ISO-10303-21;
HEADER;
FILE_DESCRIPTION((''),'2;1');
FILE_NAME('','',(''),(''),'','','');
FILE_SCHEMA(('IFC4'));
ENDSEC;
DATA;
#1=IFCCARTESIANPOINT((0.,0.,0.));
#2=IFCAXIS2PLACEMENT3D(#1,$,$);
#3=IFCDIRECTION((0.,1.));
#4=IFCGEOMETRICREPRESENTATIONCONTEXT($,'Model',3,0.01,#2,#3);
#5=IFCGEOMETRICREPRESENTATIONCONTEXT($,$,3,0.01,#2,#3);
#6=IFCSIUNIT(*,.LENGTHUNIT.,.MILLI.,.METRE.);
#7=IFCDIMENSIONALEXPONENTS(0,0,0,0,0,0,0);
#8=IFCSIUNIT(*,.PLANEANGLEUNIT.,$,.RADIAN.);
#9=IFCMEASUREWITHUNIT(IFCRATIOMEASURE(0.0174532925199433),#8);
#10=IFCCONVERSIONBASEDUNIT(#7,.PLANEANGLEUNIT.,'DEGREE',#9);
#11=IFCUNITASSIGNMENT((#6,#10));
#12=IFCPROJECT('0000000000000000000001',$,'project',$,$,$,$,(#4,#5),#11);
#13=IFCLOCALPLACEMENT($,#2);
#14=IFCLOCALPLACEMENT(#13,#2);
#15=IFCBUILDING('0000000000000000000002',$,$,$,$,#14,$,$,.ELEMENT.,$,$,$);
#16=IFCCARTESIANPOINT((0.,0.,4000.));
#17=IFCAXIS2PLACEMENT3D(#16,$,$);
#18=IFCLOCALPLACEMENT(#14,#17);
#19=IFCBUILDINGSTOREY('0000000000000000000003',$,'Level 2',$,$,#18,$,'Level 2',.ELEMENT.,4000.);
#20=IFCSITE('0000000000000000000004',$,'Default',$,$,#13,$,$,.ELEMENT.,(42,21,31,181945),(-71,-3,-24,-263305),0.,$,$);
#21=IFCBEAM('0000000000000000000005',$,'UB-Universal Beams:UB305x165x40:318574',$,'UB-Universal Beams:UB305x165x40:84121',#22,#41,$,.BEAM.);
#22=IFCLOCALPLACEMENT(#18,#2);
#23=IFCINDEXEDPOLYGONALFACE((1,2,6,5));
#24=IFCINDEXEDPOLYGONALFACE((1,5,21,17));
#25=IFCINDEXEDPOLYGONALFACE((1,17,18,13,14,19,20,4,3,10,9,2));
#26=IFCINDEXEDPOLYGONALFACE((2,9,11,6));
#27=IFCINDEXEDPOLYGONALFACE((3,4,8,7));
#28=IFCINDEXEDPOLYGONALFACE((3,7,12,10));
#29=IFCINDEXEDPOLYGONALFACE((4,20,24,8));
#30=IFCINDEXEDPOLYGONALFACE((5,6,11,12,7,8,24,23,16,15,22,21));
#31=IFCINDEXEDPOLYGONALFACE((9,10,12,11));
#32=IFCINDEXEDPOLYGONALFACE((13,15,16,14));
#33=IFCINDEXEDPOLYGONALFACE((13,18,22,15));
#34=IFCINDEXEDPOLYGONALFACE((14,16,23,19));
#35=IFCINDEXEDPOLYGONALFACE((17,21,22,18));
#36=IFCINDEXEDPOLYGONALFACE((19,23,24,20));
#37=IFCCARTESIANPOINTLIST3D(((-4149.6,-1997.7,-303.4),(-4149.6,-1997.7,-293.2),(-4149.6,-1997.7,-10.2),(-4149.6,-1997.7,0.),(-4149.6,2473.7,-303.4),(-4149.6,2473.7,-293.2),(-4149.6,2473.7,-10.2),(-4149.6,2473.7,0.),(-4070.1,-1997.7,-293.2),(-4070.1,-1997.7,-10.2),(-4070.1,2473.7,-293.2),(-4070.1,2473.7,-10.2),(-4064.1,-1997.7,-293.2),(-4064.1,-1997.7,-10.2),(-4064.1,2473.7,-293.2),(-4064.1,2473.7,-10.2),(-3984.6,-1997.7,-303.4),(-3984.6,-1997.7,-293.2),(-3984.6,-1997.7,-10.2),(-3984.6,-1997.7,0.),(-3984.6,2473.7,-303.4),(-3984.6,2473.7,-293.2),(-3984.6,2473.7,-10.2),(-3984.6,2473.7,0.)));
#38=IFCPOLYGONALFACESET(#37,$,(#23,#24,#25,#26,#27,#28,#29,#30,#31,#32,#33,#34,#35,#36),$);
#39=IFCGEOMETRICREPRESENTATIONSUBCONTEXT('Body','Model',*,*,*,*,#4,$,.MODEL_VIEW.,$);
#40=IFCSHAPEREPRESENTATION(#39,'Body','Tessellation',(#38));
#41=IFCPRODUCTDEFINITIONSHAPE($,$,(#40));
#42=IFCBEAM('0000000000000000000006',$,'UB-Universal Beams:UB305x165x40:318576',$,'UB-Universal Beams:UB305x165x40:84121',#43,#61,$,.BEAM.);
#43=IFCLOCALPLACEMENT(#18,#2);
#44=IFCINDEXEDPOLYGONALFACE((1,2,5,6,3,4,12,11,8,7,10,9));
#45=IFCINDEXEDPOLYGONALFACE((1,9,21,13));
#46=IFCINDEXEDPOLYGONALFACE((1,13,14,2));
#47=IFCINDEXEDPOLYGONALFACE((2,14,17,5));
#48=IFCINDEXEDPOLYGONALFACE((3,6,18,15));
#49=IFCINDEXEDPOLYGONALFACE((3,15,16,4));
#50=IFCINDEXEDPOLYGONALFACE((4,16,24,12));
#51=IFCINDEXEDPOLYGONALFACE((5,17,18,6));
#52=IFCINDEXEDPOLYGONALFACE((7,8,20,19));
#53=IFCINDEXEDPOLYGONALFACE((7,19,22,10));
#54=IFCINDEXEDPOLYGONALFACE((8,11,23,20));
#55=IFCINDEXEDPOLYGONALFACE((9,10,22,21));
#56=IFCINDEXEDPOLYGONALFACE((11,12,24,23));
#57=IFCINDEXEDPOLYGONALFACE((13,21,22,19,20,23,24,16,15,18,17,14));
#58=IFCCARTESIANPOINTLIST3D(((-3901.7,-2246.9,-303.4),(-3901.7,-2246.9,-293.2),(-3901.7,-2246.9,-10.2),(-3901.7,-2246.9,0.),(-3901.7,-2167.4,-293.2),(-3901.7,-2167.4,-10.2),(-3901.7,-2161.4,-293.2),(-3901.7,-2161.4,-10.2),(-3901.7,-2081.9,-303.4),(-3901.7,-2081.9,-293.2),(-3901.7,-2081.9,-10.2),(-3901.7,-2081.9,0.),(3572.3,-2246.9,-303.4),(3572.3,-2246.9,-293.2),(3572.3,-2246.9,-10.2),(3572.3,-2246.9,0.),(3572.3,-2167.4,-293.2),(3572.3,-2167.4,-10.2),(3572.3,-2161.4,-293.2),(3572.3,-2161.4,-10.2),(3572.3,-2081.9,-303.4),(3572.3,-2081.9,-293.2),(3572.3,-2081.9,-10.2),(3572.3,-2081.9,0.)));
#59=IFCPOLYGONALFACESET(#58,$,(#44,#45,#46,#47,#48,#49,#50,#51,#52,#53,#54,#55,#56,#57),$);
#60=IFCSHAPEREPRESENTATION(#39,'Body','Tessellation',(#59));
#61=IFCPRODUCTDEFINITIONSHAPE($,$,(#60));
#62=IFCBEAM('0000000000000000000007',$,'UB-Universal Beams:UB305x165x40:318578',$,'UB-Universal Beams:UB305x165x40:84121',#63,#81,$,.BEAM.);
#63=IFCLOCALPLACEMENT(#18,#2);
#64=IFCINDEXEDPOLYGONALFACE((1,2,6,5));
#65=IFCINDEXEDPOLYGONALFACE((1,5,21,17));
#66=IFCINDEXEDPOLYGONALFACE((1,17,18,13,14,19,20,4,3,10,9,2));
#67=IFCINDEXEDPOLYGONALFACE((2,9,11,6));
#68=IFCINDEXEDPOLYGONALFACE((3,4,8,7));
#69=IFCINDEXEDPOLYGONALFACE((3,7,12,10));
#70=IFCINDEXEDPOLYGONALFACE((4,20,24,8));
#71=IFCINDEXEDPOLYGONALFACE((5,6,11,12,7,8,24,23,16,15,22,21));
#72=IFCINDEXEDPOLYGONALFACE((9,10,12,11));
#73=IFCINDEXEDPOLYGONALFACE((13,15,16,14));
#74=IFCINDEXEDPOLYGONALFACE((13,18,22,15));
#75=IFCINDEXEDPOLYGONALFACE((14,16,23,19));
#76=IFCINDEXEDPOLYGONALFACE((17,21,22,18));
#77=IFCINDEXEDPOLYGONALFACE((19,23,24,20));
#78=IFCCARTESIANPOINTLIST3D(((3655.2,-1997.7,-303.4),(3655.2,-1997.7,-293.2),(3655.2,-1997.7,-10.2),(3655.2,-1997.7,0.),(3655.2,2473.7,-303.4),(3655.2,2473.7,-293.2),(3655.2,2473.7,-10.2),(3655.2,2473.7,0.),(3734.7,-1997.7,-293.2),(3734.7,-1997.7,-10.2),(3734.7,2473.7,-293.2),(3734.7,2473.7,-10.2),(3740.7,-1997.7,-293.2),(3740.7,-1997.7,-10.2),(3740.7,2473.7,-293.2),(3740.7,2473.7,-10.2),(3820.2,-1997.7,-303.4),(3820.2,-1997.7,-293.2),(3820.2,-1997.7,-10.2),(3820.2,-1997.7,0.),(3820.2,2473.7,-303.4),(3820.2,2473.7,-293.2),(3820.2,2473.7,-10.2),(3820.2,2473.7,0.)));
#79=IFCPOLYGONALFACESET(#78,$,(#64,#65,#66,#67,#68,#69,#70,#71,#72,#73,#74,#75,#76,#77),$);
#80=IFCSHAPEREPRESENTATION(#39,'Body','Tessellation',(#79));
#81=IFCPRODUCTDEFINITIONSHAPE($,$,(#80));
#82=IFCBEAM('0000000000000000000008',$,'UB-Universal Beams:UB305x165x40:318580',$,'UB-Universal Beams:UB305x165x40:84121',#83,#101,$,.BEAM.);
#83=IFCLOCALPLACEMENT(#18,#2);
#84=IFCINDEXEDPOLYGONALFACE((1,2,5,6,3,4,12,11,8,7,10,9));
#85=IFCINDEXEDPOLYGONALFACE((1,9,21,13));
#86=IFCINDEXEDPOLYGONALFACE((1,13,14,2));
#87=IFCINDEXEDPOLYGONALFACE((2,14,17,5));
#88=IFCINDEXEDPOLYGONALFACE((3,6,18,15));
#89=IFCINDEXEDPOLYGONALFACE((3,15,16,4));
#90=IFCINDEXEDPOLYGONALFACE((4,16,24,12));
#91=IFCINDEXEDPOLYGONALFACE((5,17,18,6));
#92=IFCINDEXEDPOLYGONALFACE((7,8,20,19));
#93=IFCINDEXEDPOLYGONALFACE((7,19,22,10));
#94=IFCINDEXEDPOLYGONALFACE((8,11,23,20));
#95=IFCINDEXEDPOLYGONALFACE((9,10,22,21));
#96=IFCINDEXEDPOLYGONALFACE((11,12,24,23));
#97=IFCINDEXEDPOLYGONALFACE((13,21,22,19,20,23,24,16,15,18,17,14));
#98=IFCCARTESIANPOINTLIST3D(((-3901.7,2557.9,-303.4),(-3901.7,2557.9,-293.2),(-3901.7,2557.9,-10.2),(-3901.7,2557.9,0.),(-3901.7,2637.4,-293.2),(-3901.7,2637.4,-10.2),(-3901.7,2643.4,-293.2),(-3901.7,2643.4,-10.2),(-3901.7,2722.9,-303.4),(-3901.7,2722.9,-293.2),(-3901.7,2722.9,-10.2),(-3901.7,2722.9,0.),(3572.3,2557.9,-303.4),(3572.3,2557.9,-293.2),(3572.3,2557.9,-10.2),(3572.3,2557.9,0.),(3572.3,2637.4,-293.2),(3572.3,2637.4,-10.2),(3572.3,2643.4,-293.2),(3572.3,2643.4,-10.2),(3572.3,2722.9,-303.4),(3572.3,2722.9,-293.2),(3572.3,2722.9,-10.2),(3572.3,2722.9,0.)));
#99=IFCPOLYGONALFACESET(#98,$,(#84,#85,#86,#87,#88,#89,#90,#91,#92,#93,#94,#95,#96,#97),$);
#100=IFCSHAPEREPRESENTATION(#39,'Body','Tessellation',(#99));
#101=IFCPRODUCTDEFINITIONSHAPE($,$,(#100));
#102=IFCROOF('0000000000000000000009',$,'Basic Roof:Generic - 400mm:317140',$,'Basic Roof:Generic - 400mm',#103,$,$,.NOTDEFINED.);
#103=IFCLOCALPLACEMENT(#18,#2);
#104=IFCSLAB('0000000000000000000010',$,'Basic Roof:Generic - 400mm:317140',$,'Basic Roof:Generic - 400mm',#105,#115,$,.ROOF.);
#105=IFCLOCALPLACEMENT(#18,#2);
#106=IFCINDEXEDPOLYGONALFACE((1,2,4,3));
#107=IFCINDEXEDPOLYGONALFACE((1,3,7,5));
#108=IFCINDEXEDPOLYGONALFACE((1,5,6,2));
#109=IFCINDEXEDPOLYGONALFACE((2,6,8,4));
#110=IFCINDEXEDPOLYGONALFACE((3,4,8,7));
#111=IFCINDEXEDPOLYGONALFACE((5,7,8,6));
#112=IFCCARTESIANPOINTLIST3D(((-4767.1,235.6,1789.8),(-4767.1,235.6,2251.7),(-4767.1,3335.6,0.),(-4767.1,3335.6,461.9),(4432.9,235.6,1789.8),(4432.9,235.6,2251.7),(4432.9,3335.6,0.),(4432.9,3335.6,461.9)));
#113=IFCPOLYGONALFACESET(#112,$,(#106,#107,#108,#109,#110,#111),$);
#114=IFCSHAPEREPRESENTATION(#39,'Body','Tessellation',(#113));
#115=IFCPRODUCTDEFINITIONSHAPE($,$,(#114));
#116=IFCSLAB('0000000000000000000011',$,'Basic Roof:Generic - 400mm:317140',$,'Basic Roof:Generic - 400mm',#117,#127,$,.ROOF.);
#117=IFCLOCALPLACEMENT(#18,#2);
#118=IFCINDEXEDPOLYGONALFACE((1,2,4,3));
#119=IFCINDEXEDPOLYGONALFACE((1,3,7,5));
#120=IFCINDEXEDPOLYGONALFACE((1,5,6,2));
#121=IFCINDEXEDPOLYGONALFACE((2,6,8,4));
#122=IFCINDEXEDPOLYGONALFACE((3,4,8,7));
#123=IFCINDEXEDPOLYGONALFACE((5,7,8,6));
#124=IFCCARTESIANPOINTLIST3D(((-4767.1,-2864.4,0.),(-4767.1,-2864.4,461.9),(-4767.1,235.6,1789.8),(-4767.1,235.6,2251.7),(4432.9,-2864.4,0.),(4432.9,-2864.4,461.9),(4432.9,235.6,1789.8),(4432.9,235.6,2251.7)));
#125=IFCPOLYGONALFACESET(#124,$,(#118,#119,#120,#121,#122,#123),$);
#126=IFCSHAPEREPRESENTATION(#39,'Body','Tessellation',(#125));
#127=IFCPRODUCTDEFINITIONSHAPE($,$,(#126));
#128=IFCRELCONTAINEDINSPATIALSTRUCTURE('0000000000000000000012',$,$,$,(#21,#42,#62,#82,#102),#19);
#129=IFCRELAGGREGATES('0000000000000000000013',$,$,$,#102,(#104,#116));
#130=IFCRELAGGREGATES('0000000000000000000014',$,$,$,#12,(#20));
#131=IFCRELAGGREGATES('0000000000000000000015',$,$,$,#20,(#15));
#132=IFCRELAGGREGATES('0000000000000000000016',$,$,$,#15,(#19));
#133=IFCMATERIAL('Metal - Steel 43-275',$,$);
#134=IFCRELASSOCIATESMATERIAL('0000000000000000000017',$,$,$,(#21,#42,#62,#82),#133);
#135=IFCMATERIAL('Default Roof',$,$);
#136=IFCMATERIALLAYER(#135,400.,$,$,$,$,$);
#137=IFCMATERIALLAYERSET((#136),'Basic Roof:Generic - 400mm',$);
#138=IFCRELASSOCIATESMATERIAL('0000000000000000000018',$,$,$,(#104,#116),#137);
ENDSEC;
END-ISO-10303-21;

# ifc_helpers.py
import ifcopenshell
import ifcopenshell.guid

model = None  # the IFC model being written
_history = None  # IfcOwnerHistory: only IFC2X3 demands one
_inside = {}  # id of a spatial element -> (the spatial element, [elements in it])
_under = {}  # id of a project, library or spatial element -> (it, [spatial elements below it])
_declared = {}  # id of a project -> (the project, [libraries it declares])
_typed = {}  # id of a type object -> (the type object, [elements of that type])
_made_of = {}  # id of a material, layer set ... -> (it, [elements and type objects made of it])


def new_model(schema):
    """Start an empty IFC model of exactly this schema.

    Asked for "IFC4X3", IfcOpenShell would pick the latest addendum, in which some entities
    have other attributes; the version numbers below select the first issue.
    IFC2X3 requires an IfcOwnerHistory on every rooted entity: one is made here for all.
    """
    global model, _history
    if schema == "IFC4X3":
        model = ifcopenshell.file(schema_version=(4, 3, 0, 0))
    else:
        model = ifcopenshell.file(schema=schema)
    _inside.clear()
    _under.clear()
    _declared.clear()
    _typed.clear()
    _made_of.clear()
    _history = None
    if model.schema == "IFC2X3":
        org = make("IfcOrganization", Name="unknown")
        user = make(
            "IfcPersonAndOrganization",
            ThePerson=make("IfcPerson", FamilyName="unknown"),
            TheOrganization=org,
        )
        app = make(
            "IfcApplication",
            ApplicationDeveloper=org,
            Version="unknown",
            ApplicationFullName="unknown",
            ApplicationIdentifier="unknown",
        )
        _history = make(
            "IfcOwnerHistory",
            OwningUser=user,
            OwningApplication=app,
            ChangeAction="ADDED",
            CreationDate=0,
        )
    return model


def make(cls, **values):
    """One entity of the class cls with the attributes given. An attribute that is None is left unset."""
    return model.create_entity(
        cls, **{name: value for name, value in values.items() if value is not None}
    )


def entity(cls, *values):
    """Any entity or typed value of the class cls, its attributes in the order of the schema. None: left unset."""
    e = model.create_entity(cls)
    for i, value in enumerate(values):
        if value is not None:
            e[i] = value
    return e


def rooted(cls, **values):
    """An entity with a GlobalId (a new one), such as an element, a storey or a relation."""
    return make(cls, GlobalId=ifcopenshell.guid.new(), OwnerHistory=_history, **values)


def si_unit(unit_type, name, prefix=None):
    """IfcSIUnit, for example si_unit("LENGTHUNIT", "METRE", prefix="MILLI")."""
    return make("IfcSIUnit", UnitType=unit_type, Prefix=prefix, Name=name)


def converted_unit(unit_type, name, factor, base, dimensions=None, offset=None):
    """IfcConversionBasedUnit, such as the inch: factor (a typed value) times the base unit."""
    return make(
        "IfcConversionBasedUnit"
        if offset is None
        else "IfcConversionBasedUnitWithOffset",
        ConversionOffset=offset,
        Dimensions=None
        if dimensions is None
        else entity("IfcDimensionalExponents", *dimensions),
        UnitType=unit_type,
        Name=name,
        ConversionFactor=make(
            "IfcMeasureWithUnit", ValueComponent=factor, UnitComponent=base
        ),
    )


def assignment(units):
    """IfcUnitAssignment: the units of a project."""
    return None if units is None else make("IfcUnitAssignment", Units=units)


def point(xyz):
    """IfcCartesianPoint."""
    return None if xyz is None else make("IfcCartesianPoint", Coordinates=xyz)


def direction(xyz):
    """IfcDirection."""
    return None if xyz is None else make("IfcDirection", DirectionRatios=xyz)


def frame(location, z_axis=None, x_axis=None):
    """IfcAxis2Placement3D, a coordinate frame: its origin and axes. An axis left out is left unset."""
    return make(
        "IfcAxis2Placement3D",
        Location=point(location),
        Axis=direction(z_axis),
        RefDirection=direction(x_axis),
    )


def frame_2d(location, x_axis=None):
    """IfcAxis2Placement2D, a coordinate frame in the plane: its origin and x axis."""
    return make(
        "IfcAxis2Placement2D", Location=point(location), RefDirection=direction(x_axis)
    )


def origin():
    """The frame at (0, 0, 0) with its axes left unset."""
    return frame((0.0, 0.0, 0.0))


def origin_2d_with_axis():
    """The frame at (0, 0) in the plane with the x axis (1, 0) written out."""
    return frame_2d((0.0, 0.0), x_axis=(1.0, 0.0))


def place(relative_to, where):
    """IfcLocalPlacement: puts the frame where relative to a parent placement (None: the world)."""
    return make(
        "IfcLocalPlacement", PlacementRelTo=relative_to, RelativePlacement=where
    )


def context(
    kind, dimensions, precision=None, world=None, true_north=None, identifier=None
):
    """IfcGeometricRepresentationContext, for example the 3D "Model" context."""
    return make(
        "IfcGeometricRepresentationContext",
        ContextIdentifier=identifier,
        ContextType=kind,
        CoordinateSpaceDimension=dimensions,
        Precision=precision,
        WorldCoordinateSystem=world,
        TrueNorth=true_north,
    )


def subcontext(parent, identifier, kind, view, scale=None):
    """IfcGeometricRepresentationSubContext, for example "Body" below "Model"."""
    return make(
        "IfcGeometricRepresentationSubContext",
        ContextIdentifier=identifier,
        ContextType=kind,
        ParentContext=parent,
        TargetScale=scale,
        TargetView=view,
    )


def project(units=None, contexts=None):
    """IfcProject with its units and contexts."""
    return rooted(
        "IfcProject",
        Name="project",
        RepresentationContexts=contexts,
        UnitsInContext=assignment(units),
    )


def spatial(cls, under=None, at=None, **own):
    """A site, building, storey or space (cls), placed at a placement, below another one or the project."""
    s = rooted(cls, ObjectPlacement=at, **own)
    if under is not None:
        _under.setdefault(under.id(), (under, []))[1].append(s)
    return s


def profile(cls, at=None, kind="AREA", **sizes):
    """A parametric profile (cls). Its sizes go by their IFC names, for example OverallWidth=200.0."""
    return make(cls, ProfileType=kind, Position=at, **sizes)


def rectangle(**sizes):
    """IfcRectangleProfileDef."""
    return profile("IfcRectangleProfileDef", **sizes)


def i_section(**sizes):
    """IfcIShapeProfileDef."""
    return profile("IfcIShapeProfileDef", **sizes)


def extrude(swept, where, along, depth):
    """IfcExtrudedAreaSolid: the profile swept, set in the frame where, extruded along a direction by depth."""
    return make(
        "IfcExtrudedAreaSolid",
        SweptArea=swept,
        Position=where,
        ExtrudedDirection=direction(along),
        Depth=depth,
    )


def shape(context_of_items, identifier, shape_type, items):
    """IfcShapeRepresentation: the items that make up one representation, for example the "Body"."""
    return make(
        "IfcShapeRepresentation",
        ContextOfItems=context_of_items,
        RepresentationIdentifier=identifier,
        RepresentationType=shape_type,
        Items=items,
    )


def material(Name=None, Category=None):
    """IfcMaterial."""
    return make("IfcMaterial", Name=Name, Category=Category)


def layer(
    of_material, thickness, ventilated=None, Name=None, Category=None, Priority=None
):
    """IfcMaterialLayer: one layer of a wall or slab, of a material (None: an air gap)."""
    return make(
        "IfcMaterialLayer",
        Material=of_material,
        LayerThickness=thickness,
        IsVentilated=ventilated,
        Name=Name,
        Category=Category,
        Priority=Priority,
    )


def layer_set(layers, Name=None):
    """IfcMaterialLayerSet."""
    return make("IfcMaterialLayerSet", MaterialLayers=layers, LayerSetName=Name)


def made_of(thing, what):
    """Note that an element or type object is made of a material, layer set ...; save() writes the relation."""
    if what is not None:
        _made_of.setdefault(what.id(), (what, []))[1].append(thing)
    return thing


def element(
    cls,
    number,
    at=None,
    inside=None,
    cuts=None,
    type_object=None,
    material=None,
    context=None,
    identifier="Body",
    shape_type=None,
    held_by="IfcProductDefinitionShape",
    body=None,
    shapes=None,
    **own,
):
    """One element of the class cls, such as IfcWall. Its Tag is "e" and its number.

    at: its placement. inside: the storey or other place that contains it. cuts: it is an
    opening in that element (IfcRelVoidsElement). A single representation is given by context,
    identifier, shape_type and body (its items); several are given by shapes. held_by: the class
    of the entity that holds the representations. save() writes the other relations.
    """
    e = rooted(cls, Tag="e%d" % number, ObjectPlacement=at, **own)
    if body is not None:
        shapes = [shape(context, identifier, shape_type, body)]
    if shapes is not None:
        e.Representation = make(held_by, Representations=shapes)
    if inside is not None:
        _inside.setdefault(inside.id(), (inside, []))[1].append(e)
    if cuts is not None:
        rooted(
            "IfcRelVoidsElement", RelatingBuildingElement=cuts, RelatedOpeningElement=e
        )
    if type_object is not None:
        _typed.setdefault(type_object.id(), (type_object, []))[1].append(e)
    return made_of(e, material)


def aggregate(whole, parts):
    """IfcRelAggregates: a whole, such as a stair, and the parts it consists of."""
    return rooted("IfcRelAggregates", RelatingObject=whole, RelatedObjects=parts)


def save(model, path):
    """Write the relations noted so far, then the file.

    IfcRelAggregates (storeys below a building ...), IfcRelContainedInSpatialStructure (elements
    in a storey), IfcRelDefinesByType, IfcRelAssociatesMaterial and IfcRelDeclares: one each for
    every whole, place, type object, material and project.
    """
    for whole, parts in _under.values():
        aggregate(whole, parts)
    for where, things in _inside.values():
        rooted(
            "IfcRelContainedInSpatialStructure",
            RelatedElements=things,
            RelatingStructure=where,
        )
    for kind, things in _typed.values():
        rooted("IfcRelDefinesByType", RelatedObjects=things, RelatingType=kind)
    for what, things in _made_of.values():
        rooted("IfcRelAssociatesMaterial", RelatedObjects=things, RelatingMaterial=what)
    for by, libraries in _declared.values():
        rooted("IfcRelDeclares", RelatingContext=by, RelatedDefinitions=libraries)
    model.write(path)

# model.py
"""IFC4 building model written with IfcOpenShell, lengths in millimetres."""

from ifc_helpers import new_model, entity, si_unit, converted_unit, direction, frame, frame_2d, origin, origin_2d_with_axis, place, context, subcontext, project, spatial, rectangle, i_section, extrude, material, layer, layer_set, element, aggregate, save


model = new_model("IFC4")

# Units and contexts
model_context = context("Model", 3, precision=0.01, world=origin(), true_north=direction((0.0, 1.0)))
context_of_model = context(None, 3, precision=0.01, world=origin(), true_north=direction((0.0, 1.0)))
body_context = subcontext(model_context, "Body", "Model", "MODEL_VIEW")
ifc_project = project(units=[si_unit("LENGTHUNIT", "METRE", prefix="MILLI"), converted_unit("PLANEANGLEUNIT", "DEGREE", entity("IfcRatioMeasure", 0.0174532925199433), si_unit("PLANEANGLEUNIT", "RADIAN"), dimensions=[0, 0, 0, 0, 0, 0, 0])], contexts=[model_context, context_of_model])

# Site, building, storey
site_placement = place(None, origin())
site = spatial("IfcSite", under=ifc_project, at=site_placement, Name="Default", CompositionType="ELEMENT", RefLatitude=(42, 21, 31, 181945), RefLongitude=(-71, -3, -24, -263305), RefElevation=0.0)
building_placement = place(site_placement, origin())
building = spatial("IfcBuilding", under=site, at=building_placement, CompositionType="ELEMENT")
storey_placement = place(building_placement, frame((0.0, 0.0, 4000.0)))
storey = spatial("IfcBuildingStorey", under=building, at=storey_placement, Name="Level 2", LongName="Level 2", CompositionType="ELEMENT", Elevation=4000.0)

# Beams
ifc_material_1 = material(Name="Metal - Steel 43-275")
beam_1_placement = place(storey_placement, frame((-4067.1, 2640.4, 0.0), z_axis=(0.0, 0.0, 1.0), x_axis=(0.0, -1.0, 0.0)))
element("IfcBeam", 1, at=beam_1_placement, inside=storey, material=ifc_material_1, Name="UB-Universal Beams:UB305x165x40:318574", ObjectType="UB-Universal Beams:UB305x165x40:84121", PredefinedType="BEAM", context=body_context, shape_type="SweptSolid", body=[
    extrude(i_section(OverallWidth=165.0, OverallDepth=303.4, WebThickness=6.0, FlangeThickness=10.2, at=frame_2d((0.0, 0.0), x_axis=(0.0, 1.0))), frame((166.7, 0.0, -151.7), z_axis=(1.0, 0.0, 0.0), x_axis=(0.0, 0.0, -1.0)), (0.0, 0.0, 1.0), 4471.4),
])
beam_2_placement = place(storey_placement, frame((-4067.1, -2164.4, 0.0)))
element("IfcBeam", 2, at=beam_2_placement, inside=storey, material=ifc_material_1, Name="UB-Universal Beams:UB305x165x40:318576", ObjectType="UB-Universal Beams:UB305x165x40:84121", PredefinedType="BEAM", context=body_context, shape_type="SweptSolid", body=[
    extrude(i_section(OverallWidth=165.0, OverallDepth=303.4, WebThickness=6.0, FlangeThickness=10.2, at=frame_2d((0.0, 0.0), x_axis=(0.0, 1.0))), frame((165.4, 0.0, -151.7), z_axis=(1.0, 0.0, 0.0), x_axis=(0.0, 0.0, -1.0)), (0.0, 0.0, 1.0), 7474.0),
])
beam_3_placement = place(storey_placement, frame((3737.7, 2640.4, 0.0), z_axis=(0.0, 0.0, 1.0), x_axis=(0.0, -1.0, 0.0)))
element("IfcBeam", 3, at=beam_3_placement, inside=storey, material=ifc_material_1, Name="UB-Universal Beams:UB305x165x40:318578", ObjectType="UB-Universal Beams:UB305x165x40:84121", PredefinedType="BEAM", context=body_context, shape_type="SweptSolid", body=[
    extrude(i_section(OverallWidth=165.0, OverallDepth=303.4, WebThickness=6.0, FlangeThickness=10.2, at=frame_2d((0.0, 0.0), x_axis=(0.0, 1.0))), frame((166.7, 0.0, -151.7), z_axis=(1.0, 0.0, 0.0), x_axis=(0.0, 0.0, -1.0)), (0.0, 0.0, 1.0), 4471.4),
])
beam_4_placement = place(storey_placement, frame((-4067.1, 2640.4, 0.0)))
element("IfcBeam", 4, at=beam_4_placement, inside=storey, material=ifc_material_1, Name="UB-Universal Beams:UB305x165x40:318580", ObjectType="UB-Universal Beams:UB305x165x40:84121", PredefinedType="BEAM", context=body_context, shape_type="SweptSolid", body=[
    extrude(i_section(OverallWidth=165.0, OverallDepth=303.4, WebThickness=6.0, FlangeThickness=10.2, at=frame_2d((0.0, 0.0), x_axis=(0.0, 1.0))), frame((165.4, 0.0, -151.7), z_axis=(1.0, 0.0, 0.0), x_axis=(0.0, 0.0, -1.0)), (0.0, 0.0, 1.0), 7474.0),
])

# Roof, slabs
roof_placement = place(storey_placement, frame((-4767.1, -2864.4, 0.0)))
roof = element("IfcRoof", 5, at=roof_placement, inside=storey, Name="Basic Roof:Generic - 400mm:317140", ObjectType="Basic Roof:Generic - 400mm", PredefinedType="NOTDEFINED")
ifc_material_2 = material(Name="Default Roof")
ifc_layer = layer(ifc_material_2, 400.0)
ifc_layer_set = layer_set([ifc_layer], Name="Basic Roof:Generic - 400mm")
slab_1_placement = place(roof_placement, origin())
slab_1 = element("IfcSlab", 6, at=slab_1_placement, material=ifc_layer_set, Name="Basic Roof:Generic - 400mm:317140", ObjectType="Basic Roof:Generic - 400mm", PredefinedType="ROOF", context=body_context, shape_type="SweptSolid", body=[
    extrude(rectangle(XDim=9200.0, YDim=3579.6, at=origin_2d_with_axis()), frame((4600.0, 4650.0, 894.9), z_axis=(0.0, 0.5, 0.866025), x_axis=(1.0, 0.0, 0.0)), (0.0, -0.5, 0.866025), 461.9),
])
slab_2_placement = place(roof_placement, origin())
slab_2 = element("IfcSlab", 7, at=slab_2_placement, material=ifc_layer_set, Name="Basic Roof:Generic - 400mm:317140", ObjectType="Basic Roof:Generic - 400mm", PredefinedType="ROOF", context=body_context, shape_type="SweptSolid", body=[
    extrude(rectangle(XDim=3579.6, YDim=9200.0, at=frame_2d((0.0, 0.0), x_axis=(0.0, 1.0))), frame((4600.0, 1550.0, 894.9), z_axis=(0.0, -0.5, 0.866025), x_axis=(1.0, 0.0, 0.0)), (0.0, 0.5, 0.866025), 461.9),
])
aggregate(roof, [slab_1, slab_2])

save(model, "model.ifc")
